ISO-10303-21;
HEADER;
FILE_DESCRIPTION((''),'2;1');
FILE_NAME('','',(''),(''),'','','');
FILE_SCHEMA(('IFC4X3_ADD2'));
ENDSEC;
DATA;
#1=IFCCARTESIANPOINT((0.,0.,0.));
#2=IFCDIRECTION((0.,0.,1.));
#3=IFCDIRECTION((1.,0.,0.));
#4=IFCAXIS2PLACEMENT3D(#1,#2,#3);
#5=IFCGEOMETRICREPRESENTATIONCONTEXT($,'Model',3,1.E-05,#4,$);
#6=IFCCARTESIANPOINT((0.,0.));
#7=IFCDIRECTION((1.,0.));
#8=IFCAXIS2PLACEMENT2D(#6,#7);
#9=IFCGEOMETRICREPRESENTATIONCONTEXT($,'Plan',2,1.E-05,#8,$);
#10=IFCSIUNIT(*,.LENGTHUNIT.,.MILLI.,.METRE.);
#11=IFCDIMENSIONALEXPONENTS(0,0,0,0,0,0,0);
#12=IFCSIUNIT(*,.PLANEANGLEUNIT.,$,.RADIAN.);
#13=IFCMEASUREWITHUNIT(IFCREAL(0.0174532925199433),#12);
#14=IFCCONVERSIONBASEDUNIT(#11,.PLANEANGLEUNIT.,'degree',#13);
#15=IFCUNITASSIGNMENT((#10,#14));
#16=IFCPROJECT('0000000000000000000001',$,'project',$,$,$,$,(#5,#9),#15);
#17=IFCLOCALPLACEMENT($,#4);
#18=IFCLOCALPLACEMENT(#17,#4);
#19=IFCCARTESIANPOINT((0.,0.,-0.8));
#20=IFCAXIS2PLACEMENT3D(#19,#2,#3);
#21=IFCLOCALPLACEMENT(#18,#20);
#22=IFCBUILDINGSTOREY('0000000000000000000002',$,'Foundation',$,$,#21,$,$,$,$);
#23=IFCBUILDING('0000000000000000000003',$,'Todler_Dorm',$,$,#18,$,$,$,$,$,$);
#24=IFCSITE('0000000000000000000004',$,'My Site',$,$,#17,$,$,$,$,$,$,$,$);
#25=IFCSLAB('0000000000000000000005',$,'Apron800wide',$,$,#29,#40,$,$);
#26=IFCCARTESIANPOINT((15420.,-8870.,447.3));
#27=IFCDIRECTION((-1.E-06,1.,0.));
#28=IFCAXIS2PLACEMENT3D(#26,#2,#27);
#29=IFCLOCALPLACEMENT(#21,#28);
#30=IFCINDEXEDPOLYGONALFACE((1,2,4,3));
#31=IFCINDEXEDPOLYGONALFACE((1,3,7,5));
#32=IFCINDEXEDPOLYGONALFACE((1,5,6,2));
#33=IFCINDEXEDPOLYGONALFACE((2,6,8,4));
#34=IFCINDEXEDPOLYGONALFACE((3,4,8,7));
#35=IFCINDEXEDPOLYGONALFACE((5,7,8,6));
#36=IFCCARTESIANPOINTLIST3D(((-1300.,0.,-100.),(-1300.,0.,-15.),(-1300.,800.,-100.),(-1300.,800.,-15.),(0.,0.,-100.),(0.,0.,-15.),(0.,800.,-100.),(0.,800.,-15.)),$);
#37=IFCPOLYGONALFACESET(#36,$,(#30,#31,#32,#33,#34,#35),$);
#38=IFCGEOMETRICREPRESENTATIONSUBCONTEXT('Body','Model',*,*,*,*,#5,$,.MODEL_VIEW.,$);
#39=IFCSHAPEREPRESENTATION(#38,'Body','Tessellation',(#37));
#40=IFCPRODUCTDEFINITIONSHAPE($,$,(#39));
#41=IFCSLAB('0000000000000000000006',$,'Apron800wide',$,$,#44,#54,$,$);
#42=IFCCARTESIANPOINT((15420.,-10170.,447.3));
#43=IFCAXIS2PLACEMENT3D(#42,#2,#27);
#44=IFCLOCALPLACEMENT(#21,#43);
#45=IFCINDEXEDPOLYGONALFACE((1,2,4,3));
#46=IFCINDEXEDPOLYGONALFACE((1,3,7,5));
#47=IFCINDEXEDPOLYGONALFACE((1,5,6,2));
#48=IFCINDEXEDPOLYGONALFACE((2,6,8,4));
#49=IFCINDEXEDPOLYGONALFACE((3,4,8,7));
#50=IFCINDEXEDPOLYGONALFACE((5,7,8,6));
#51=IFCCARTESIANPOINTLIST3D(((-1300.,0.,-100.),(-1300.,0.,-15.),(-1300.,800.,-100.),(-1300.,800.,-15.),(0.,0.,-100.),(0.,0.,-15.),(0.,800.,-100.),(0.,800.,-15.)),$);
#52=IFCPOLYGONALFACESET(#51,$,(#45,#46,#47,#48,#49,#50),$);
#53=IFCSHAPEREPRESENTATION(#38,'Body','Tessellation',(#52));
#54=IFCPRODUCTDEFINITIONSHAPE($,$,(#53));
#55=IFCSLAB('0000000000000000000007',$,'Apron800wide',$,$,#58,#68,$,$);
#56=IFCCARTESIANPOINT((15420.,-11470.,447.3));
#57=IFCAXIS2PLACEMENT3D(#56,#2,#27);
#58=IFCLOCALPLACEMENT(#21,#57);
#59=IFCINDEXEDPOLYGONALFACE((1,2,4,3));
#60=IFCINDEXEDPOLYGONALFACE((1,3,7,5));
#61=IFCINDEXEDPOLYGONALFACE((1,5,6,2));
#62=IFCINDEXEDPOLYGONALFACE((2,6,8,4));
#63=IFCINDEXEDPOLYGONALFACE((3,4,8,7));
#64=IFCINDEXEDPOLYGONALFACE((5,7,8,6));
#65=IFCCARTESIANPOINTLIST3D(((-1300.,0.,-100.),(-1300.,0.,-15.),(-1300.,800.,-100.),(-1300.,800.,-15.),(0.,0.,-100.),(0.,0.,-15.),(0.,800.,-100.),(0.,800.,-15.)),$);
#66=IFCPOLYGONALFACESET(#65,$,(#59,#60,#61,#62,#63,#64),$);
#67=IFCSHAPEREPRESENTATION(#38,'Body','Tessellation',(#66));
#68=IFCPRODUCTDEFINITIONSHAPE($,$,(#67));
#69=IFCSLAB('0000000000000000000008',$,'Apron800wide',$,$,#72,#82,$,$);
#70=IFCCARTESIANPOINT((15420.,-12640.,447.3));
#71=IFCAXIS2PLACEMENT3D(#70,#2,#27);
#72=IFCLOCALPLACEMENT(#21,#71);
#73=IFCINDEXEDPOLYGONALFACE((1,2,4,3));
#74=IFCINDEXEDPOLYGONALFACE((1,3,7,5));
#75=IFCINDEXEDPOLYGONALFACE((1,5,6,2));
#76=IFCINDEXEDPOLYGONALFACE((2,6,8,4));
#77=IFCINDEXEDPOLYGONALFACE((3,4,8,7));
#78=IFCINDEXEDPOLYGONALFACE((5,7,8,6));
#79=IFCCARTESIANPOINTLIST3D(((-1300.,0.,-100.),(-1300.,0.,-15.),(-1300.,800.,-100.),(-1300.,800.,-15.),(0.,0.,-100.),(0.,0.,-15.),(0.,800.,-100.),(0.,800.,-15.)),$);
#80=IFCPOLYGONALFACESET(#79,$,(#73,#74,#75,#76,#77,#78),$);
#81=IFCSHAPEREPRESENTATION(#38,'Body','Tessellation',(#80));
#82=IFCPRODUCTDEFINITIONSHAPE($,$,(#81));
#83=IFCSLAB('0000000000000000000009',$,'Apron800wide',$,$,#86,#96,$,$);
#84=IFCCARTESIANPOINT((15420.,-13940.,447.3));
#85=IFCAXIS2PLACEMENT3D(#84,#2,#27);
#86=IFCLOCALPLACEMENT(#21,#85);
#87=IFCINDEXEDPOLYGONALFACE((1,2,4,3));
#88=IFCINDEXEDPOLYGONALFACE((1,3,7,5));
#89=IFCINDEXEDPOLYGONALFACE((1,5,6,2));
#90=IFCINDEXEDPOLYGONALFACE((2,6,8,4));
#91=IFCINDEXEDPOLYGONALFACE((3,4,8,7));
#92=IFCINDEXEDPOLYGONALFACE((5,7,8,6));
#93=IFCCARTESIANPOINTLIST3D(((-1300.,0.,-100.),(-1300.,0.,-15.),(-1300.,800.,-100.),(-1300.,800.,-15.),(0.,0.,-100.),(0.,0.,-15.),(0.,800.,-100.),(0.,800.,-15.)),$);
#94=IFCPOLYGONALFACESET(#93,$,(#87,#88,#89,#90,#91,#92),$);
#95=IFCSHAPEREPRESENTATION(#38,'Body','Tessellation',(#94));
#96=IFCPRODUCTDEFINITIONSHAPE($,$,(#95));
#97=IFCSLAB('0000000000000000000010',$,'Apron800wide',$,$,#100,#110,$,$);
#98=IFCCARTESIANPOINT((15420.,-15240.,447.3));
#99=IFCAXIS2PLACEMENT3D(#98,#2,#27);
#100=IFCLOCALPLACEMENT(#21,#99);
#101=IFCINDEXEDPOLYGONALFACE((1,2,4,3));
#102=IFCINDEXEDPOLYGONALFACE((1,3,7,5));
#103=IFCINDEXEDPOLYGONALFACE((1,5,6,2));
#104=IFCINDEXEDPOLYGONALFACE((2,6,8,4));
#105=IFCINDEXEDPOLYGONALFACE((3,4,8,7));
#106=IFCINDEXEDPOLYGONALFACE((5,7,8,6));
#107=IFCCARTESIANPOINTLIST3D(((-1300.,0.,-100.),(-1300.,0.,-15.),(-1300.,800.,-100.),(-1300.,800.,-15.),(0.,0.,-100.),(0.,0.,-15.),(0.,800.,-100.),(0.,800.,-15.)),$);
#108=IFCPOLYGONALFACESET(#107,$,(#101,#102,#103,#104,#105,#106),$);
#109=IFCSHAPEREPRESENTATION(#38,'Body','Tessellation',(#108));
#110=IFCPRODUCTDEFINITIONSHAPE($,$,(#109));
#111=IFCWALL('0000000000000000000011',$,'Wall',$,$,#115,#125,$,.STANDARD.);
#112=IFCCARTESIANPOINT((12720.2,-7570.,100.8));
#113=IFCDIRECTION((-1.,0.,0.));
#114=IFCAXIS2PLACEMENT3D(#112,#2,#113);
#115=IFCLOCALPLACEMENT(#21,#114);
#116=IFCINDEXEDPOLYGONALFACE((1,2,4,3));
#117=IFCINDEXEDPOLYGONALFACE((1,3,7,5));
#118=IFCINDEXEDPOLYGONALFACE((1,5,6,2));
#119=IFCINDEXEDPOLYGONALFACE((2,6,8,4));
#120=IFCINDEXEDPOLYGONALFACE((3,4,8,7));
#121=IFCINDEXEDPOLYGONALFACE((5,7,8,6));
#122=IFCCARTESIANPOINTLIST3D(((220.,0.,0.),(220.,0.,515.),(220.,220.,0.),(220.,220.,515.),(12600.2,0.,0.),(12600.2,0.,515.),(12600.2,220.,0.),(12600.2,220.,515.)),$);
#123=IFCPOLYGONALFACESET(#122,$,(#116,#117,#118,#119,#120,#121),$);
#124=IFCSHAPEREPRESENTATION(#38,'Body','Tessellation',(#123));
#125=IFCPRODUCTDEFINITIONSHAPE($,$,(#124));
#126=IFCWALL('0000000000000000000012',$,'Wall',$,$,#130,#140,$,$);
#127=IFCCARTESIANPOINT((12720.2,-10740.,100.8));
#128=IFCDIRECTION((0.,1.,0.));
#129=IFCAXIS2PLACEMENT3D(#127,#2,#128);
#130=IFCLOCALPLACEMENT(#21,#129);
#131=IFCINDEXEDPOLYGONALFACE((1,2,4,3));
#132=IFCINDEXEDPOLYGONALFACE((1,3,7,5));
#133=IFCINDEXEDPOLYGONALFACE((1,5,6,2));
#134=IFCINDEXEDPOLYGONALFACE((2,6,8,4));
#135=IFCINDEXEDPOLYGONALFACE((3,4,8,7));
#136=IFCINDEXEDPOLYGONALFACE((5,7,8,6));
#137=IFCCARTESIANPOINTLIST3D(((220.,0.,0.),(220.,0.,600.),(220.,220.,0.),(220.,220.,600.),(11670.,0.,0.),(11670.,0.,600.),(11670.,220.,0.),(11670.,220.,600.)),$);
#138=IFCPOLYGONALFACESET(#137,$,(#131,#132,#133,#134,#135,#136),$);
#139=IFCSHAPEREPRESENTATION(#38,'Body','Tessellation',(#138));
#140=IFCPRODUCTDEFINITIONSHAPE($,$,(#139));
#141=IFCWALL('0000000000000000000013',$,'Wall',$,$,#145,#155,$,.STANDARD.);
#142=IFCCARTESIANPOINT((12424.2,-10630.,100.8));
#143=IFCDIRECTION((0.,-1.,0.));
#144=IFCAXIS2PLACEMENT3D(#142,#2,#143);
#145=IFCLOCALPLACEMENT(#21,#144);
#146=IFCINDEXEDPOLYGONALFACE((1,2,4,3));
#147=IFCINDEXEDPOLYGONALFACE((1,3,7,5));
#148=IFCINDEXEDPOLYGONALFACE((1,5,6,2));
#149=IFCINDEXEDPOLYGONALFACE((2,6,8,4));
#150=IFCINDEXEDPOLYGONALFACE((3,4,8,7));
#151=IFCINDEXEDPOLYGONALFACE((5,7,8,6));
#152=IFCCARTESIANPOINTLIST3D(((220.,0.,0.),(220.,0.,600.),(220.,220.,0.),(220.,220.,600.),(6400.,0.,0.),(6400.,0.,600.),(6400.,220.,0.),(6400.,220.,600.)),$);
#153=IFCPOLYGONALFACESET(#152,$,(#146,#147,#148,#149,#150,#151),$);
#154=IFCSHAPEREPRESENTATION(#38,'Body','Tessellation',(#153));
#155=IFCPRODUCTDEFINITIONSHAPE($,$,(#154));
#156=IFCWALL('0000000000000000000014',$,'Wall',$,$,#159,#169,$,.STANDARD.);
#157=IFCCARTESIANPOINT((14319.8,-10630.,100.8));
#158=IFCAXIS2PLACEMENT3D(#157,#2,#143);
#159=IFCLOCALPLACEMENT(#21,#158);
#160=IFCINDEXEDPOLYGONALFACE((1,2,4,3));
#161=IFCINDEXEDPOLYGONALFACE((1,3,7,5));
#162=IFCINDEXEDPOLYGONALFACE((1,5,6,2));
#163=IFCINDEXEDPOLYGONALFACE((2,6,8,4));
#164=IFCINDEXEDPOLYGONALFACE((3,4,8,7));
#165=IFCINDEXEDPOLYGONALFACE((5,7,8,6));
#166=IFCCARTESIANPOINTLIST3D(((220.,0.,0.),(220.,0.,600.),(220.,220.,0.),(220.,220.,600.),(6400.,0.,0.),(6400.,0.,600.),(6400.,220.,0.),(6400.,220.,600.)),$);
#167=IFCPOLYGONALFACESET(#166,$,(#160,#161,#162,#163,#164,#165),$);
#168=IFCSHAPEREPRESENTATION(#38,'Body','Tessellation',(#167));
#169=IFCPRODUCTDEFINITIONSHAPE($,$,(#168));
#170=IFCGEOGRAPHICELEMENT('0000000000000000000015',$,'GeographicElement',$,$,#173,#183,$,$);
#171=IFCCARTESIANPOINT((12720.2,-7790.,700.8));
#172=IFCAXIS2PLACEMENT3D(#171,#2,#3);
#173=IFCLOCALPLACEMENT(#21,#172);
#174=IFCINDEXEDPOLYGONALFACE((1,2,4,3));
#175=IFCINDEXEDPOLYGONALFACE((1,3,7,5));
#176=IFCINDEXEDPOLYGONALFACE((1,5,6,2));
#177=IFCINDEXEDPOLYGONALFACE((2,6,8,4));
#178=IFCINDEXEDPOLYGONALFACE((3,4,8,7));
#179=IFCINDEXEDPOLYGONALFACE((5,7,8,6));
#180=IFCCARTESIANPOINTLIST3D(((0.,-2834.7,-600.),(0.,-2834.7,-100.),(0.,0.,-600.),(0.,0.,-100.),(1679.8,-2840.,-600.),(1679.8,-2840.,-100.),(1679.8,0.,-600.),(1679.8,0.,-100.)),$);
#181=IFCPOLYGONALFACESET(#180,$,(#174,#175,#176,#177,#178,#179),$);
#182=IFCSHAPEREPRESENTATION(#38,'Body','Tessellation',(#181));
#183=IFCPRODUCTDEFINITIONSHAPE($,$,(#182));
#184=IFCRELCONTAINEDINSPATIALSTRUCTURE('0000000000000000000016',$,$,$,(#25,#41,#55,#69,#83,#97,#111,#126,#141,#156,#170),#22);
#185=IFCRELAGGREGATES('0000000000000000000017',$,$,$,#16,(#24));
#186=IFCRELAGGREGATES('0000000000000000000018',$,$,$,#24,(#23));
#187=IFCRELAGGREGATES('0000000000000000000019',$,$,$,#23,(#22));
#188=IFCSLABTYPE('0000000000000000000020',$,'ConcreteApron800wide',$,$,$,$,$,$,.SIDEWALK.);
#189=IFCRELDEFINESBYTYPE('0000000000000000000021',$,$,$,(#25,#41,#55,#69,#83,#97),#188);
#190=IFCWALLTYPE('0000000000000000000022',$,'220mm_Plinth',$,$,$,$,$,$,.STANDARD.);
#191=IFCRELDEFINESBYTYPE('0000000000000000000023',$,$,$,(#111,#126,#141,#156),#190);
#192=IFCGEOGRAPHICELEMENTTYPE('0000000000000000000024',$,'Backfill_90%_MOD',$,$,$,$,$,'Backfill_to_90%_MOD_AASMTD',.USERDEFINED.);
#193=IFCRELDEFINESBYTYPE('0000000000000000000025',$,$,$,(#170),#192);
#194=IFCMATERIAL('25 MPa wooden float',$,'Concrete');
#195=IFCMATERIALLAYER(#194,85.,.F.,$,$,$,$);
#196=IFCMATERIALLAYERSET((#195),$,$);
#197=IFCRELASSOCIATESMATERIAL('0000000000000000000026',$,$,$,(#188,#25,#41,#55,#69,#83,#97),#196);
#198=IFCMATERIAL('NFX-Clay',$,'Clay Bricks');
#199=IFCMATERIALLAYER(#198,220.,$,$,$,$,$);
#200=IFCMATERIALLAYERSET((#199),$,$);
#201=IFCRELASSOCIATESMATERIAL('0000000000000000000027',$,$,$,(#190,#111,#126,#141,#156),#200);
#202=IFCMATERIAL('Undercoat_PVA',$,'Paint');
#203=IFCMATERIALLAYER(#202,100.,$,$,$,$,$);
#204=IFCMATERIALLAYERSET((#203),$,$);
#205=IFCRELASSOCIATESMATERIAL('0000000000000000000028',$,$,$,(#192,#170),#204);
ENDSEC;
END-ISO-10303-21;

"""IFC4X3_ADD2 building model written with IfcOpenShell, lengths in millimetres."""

from ifc_helpers import new_model, entity, si_unit, converted_unit, frame, origin_with_axes, origin_2d_with_axis, place, context, subcontext, project, spatial, line, indexed_curve, outline, extrude, material, layer, layer_set, layer_usage, type_object, element, save


model = new_model("IFC4X3_ADD2")

# Units and contexts
model_context = context("Model", 3, precision=1e-05, world=origin_with_axes())
plan_context = context("Plan", 2, precision=1e-05, world=origin_2d_with_axis())
body_context = subcontext(model_context, "Body", "Model", "MODEL_VIEW")
ifc_project = project(units=[si_unit("LENGTHUNIT", "METRE", prefix="MILLI"), converted_unit("PLANEANGLEUNIT", "degree", entity("IfcReal", 0.0174532925199433), si_unit("PLANEANGLEUNIT", "RADIAN"), dimensions=[0, 0, 0, 0, 0, 0, 0])], contexts=[model_context, plan_context])

# Site, building, storey
site_placement = place(None, origin_with_axes())
site = spatial("IfcSite", under=ifc_project, at=site_placement, Name="My Site")
building_placement = place(site_placement, origin_with_axes())
building = spatial("IfcBuilding", under=site, at=building_placement, Name="Todler_Dorm")
storey_placement = place(building_placement, frame((0.0, 0.0, -0.8), z_axis=(0.0, 0.0, 1.0), x_axis=(1.0, 0.0, 0.0)))
storey = spatial("IfcBuildingStorey", under=building, at=storey_placement, Name="Foundation")

# Shared definitions
ifc_material_1 = material(Name="Undercoat_PVA", Category="Paint")

# Slabs
ifc_material_2 = material(Name="25 MPa wooden float", Category="Concrete")
ifc_layer_1 = layer(ifc_material_2, 85.0, ventilated=False)
ifc_layer_set_1 = layer_set([ifc_layer_1])
slab_type = type_object("IfcSlabType", Name="ConcreteApron800wide", PredefinedType="SIDEWALK", material=ifc_layer_set_1)
ifc_layer_usage_1 = layer_usage(ifc_layer_set_1, "AXIS3", "POSITIVE", -100.0)
slab_1_placement = place(storey_placement, frame((15420.0, -8870.0, 447.3), z_axis=(0.0, 0.0, 1.0), x_axis=(-0.000001, 1.0, 0.0)))
element("IfcSlab", 1, at=slab_1_placement, inside=storey, type_object=slab_type, material=ifc_layer_usage_1, Name="Apron800wide", context=body_context, shape_type="SweptSolid", body=[
    extrude(outline(indexed_curve([(0.0, 0.0), (0.0, 800.0), (-1300.0, 800.0), (-1300.0, 0.0), (0.0, 0.0)])), frame((0.0, 0.0, -100.0), z_axis=(0.0, 0.0, 1.0), x_axis=(1.0, 0.0, 0.0)), (0.0, 0.0, 1.0), 85.0),
])
ifc_layer_usage_2 = layer_usage(ifc_layer_set_1, "AXIS3", "POSITIVE", -100.0)
slab_2_placement = place(storey_placement, frame((15420.0, -10170.0, 447.3), z_axis=(0.0, 0.0, 1.0), x_axis=(-0.000001, 1.0, 0.0)))
element("IfcSlab", 2, at=slab_2_placement, inside=storey, type_object=slab_type, material=ifc_layer_usage_2, Name="Apron800wide", context=body_context, shape_type="SweptSolid", body=[
    extrude(outline(indexed_curve([(0.0, 0.0), (0.0, 800.0), (-1300.0, 800.0), (-1300.0, 0.0), (0.0, 0.0)])), frame((0.0, 0.0, -100.0), z_axis=(0.0, 0.0, 1.0), x_axis=(1.0, 0.0, 0.0)), (0.0, 0.0, 1.0), 85.0),
])
ifc_layer_usage_3 = layer_usage(ifc_layer_set_1, "AXIS3", "POSITIVE", -100.0)
slab_3_placement = place(storey_placement, frame((15420.0, -11470.0, 447.3), z_axis=(0.0, 0.0, 1.0), x_axis=(-0.000001, 1.0, 0.0)))
element("IfcSlab", 3, at=slab_3_placement, inside=storey, type_object=slab_type, material=ifc_layer_usage_3, Name="Apron800wide", context=body_context, shape_type="SweptSolid", body=[
    extrude(outline(indexed_curve([(0.0, 0.0), (0.0, 800.0), (-1300.0, 800.0), (-1300.0, 0.0), (0.0, 0.0)])), frame((0.0, 0.0, -100.0), z_axis=(0.0, 0.0, 1.0), x_axis=(1.0, 0.0, 0.0)), (0.0, 0.0, 1.0), 85.0),
])
ifc_layer_usage_4 = layer_usage(ifc_layer_set_1, "AXIS3", "POSITIVE", -100.0)
slab_4_placement = place(storey_placement, frame((15420.0, -12640.0, 447.3), z_axis=(0.0, 0.0, 1.0), x_axis=(-0.000001, 1.0, 0.0)))
element("IfcSlab", 4, at=slab_4_placement, inside=storey, type_object=slab_type, material=ifc_layer_usage_4, Name="Apron800wide", context=body_context, shape_type="SweptSolid", body=[
    extrude(outline(indexed_curve([(0.0, 0.0), (0.0, 800.0), (-1300.0, 800.0), (-1300.0, 0.0), (0.0, 0.0)])), frame((0.0, 0.0, -100.0), z_axis=(0.0, 0.0, 1.0), x_axis=(1.0, 0.0, 0.0)), (0.0, 0.0, 1.0), 85.0),
])
ifc_layer_usage_5 = layer_usage(ifc_layer_set_1, "AXIS3", "POSITIVE", -100.0)
slab_5_placement = place(storey_placement, frame((15420.0, -13940.0, 447.3), z_axis=(0.0, 0.0, 1.0), x_axis=(-0.000001, 1.0, 0.0)))
element("IfcSlab", 5, at=slab_5_placement, inside=storey, type_object=slab_type, material=ifc_layer_usage_5, Name="Apron800wide", context=body_context, shape_type="SweptSolid", body=[
    extrude(outline(indexed_curve([(0.0, 0.0), (0.0, 800.0), (-1300.0, 800.0), (-1300.0, 0.0), (0.0, 0.0)])), frame((0.0, 0.0, -100.0), z_axis=(0.0, 0.0, 1.0), x_axis=(1.0, 0.0, 0.0)), (0.0, 0.0, 1.0), 85.0),
])
ifc_layer_usage_6 = layer_usage(ifc_layer_set_1, "AXIS3", "POSITIVE", -100.0)
slab_6_placement = place(storey_placement, frame((15420.0, -15240.0, 447.3), z_axis=(0.0, 0.0, 1.0), x_axis=(-0.000001, 1.0, 0.0)))
element("IfcSlab", 6, at=slab_6_placement, inside=storey, type_object=slab_type, material=ifc_layer_usage_6, Name="Apron800wide", context=body_context, shape_type="SweptSolid", body=[
    extrude(outline(indexed_curve([(0.0, 0.0), (0.0, 800.0), (-1300.0, 800.0), (-1300.0, 0.0), (0.0, 0.0)])), frame((0.0, 0.0, -100.0), z_axis=(0.0, 0.0, 1.0), x_axis=(1.0, 0.0, 0.0)), (0.0, 0.0, 1.0), 85.0),
])

# Walls
ifc_material_3 = material(Name="NFX-Clay", Category="Clay Bricks")
ifc_layer_2 = layer(ifc_material_3, 220.0)
ifc_layer_set_2 = layer_set([ifc_layer_2])
wall_type = type_object("IfcWallType", Name="220mm_Plinth", PredefinedType="STANDARD", material=ifc_layer_set_2)
ifc_layer_usage_7 = layer_usage(ifc_layer_set_2, "AXIS2", "POSITIVE", 0.0)
wall_1_placement = place(storey_placement, frame((12720.2, -7570.0, 100.8), z_axis=(0.0, 0.0, 1.0), x_axis=(-1.0, 0.0, 0.0)))
element("IfcWall", 7, at=wall_1_placement, inside=storey, type_object=wall_type, material=ifc_layer_usage_7, Name="Wall", PredefinedType="STANDARD", context=body_context, shape_type="SweptSolid", body=[
    extrude(outline(indexed_curve([(220.0, 0.0), (220.0, 220.0), (12600.2, 220.0), (12600.2, 0.0)], segments=[line(1, 2, 3, 4, 1)])), origin_with_axes(), (0.0, 0.0, 1.0), 515.0),
])
ifc_layer_usage_8 = layer_usage(ifc_layer_set_2, "AXIS2", "POSITIVE", 0.0)
wall_2_placement = place(storey_placement, frame((12720.2, -10740.0, 100.8), z_axis=(0.0, 0.0, 1.0), x_axis=(0.0, 1.0, 0.0)))
element("IfcWall", 8, at=wall_2_placement, inside=storey, type_object=wall_type, material=ifc_layer_usage_8, Name="Wall", context=body_context, shape_type="SweptSolid", body=[
    extrude(outline(indexed_curve([(220.0, 0.0), (220.0, 220.0), (11670.0, 220.0), (11670.0, 0.0)], segments=[line(1, 2, 3, 4, 1)])), origin_with_axes(), (0.0, 0.0, 1.0), 600.0),
])
ifc_layer_usage_9 = layer_usage(ifc_layer_set_2, "AXIS2", "POSITIVE", 0.0)
wall_3_placement = place(storey_placement, frame((12424.2, -10630.0, 100.8), z_axis=(0.0, 0.0, 1.0), x_axis=(0.0, -1.0, 0.0)))
element("IfcWall", 9, at=wall_3_placement, inside=storey, type_object=wall_type, material=ifc_layer_usage_9, Name="Wall", PredefinedType="STANDARD", context=body_context, shape_type="SweptSolid", body=[
    extrude(outline(indexed_curve([(220.0, 0.0), (220.0, 220.0), (6400.0, 220.0), (6400.0, 0.0)], segments=[line(1, 2, 3, 4, 1)])), origin_with_axes(), (0.0, 0.0, 1.0), 600.0),
])
ifc_layer_usage_10 = layer_usage(ifc_layer_set_2, "AXIS2", "POSITIVE", 0.0)
wall_4_placement = place(storey_placement, frame((14319.8, -10630.0, 100.8), z_axis=(0.0, 0.0, 1.0), x_axis=(0.0, -1.0, 0.0)))
element("IfcWall", 10, at=wall_4_placement, inside=storey, type_object=wall_type, material=ifc_layer_usage_10, Name="Wall", PredefinedType="STANDARD", context=body_context, shape_type="SweptSolid", body=[
    extrude(outline(indexed_curve([(220.0, 0.0), (220.0, 220.0), (6400.0, 220.0), (6400.0, 0.0)], segments=[line(1, 2, 3, 4, 1)])), origin_with_axes(), (0.0, 0.0, 1.0), 600.0),
])

# Geographic element
ifc_layer_3 = layer(ifc_material_1, 100.0)
ifc_layer_set_3 = layer_set([ifc_layer_3])
ifc_layer_usage_11 = layer_usage(ifc_layer_set_3, "AXIS3", "POSITIVE", -100.0)
geographic_element_type = type_object("IfcGeographicElementType", Name="Backfill_90%_MOD", ElementType="Backfill_to_90%_MOD_AASMTD", PredefinedType="USERDEFINED", material=ifc_layer_set_3)
geographic_element_placement = place(storey_placement, frame((12720.2, -7790.0, 700.8), z_axis=(0.0, 0.0, 1.0), x_axis=(1.0, 0.0, 0.0)))
element("IfcGeographicElement", 11, at=geographic_element_placement, inside=storey, type_object=geographic_element_type, material=ifc_layer_usage_11, Name="GeographicElement", context=body_context, shape_type="SweptSolid", body=[
    extrude(outline(indexed_curve([(0.0, 0.0), (1679.8, 0.0), (1679.8, -2840.0), (0.0, -2834.7), (0.0, 0.0)])), frame((0.0, 0.0, -600.0), z_axis=(0.0, 0.0, 1.0), x_axis=(1.0, 0.0, 0.0)), (0.0, 0.0, 1.0), 500.0),
])

save(model, "model.ifc")
